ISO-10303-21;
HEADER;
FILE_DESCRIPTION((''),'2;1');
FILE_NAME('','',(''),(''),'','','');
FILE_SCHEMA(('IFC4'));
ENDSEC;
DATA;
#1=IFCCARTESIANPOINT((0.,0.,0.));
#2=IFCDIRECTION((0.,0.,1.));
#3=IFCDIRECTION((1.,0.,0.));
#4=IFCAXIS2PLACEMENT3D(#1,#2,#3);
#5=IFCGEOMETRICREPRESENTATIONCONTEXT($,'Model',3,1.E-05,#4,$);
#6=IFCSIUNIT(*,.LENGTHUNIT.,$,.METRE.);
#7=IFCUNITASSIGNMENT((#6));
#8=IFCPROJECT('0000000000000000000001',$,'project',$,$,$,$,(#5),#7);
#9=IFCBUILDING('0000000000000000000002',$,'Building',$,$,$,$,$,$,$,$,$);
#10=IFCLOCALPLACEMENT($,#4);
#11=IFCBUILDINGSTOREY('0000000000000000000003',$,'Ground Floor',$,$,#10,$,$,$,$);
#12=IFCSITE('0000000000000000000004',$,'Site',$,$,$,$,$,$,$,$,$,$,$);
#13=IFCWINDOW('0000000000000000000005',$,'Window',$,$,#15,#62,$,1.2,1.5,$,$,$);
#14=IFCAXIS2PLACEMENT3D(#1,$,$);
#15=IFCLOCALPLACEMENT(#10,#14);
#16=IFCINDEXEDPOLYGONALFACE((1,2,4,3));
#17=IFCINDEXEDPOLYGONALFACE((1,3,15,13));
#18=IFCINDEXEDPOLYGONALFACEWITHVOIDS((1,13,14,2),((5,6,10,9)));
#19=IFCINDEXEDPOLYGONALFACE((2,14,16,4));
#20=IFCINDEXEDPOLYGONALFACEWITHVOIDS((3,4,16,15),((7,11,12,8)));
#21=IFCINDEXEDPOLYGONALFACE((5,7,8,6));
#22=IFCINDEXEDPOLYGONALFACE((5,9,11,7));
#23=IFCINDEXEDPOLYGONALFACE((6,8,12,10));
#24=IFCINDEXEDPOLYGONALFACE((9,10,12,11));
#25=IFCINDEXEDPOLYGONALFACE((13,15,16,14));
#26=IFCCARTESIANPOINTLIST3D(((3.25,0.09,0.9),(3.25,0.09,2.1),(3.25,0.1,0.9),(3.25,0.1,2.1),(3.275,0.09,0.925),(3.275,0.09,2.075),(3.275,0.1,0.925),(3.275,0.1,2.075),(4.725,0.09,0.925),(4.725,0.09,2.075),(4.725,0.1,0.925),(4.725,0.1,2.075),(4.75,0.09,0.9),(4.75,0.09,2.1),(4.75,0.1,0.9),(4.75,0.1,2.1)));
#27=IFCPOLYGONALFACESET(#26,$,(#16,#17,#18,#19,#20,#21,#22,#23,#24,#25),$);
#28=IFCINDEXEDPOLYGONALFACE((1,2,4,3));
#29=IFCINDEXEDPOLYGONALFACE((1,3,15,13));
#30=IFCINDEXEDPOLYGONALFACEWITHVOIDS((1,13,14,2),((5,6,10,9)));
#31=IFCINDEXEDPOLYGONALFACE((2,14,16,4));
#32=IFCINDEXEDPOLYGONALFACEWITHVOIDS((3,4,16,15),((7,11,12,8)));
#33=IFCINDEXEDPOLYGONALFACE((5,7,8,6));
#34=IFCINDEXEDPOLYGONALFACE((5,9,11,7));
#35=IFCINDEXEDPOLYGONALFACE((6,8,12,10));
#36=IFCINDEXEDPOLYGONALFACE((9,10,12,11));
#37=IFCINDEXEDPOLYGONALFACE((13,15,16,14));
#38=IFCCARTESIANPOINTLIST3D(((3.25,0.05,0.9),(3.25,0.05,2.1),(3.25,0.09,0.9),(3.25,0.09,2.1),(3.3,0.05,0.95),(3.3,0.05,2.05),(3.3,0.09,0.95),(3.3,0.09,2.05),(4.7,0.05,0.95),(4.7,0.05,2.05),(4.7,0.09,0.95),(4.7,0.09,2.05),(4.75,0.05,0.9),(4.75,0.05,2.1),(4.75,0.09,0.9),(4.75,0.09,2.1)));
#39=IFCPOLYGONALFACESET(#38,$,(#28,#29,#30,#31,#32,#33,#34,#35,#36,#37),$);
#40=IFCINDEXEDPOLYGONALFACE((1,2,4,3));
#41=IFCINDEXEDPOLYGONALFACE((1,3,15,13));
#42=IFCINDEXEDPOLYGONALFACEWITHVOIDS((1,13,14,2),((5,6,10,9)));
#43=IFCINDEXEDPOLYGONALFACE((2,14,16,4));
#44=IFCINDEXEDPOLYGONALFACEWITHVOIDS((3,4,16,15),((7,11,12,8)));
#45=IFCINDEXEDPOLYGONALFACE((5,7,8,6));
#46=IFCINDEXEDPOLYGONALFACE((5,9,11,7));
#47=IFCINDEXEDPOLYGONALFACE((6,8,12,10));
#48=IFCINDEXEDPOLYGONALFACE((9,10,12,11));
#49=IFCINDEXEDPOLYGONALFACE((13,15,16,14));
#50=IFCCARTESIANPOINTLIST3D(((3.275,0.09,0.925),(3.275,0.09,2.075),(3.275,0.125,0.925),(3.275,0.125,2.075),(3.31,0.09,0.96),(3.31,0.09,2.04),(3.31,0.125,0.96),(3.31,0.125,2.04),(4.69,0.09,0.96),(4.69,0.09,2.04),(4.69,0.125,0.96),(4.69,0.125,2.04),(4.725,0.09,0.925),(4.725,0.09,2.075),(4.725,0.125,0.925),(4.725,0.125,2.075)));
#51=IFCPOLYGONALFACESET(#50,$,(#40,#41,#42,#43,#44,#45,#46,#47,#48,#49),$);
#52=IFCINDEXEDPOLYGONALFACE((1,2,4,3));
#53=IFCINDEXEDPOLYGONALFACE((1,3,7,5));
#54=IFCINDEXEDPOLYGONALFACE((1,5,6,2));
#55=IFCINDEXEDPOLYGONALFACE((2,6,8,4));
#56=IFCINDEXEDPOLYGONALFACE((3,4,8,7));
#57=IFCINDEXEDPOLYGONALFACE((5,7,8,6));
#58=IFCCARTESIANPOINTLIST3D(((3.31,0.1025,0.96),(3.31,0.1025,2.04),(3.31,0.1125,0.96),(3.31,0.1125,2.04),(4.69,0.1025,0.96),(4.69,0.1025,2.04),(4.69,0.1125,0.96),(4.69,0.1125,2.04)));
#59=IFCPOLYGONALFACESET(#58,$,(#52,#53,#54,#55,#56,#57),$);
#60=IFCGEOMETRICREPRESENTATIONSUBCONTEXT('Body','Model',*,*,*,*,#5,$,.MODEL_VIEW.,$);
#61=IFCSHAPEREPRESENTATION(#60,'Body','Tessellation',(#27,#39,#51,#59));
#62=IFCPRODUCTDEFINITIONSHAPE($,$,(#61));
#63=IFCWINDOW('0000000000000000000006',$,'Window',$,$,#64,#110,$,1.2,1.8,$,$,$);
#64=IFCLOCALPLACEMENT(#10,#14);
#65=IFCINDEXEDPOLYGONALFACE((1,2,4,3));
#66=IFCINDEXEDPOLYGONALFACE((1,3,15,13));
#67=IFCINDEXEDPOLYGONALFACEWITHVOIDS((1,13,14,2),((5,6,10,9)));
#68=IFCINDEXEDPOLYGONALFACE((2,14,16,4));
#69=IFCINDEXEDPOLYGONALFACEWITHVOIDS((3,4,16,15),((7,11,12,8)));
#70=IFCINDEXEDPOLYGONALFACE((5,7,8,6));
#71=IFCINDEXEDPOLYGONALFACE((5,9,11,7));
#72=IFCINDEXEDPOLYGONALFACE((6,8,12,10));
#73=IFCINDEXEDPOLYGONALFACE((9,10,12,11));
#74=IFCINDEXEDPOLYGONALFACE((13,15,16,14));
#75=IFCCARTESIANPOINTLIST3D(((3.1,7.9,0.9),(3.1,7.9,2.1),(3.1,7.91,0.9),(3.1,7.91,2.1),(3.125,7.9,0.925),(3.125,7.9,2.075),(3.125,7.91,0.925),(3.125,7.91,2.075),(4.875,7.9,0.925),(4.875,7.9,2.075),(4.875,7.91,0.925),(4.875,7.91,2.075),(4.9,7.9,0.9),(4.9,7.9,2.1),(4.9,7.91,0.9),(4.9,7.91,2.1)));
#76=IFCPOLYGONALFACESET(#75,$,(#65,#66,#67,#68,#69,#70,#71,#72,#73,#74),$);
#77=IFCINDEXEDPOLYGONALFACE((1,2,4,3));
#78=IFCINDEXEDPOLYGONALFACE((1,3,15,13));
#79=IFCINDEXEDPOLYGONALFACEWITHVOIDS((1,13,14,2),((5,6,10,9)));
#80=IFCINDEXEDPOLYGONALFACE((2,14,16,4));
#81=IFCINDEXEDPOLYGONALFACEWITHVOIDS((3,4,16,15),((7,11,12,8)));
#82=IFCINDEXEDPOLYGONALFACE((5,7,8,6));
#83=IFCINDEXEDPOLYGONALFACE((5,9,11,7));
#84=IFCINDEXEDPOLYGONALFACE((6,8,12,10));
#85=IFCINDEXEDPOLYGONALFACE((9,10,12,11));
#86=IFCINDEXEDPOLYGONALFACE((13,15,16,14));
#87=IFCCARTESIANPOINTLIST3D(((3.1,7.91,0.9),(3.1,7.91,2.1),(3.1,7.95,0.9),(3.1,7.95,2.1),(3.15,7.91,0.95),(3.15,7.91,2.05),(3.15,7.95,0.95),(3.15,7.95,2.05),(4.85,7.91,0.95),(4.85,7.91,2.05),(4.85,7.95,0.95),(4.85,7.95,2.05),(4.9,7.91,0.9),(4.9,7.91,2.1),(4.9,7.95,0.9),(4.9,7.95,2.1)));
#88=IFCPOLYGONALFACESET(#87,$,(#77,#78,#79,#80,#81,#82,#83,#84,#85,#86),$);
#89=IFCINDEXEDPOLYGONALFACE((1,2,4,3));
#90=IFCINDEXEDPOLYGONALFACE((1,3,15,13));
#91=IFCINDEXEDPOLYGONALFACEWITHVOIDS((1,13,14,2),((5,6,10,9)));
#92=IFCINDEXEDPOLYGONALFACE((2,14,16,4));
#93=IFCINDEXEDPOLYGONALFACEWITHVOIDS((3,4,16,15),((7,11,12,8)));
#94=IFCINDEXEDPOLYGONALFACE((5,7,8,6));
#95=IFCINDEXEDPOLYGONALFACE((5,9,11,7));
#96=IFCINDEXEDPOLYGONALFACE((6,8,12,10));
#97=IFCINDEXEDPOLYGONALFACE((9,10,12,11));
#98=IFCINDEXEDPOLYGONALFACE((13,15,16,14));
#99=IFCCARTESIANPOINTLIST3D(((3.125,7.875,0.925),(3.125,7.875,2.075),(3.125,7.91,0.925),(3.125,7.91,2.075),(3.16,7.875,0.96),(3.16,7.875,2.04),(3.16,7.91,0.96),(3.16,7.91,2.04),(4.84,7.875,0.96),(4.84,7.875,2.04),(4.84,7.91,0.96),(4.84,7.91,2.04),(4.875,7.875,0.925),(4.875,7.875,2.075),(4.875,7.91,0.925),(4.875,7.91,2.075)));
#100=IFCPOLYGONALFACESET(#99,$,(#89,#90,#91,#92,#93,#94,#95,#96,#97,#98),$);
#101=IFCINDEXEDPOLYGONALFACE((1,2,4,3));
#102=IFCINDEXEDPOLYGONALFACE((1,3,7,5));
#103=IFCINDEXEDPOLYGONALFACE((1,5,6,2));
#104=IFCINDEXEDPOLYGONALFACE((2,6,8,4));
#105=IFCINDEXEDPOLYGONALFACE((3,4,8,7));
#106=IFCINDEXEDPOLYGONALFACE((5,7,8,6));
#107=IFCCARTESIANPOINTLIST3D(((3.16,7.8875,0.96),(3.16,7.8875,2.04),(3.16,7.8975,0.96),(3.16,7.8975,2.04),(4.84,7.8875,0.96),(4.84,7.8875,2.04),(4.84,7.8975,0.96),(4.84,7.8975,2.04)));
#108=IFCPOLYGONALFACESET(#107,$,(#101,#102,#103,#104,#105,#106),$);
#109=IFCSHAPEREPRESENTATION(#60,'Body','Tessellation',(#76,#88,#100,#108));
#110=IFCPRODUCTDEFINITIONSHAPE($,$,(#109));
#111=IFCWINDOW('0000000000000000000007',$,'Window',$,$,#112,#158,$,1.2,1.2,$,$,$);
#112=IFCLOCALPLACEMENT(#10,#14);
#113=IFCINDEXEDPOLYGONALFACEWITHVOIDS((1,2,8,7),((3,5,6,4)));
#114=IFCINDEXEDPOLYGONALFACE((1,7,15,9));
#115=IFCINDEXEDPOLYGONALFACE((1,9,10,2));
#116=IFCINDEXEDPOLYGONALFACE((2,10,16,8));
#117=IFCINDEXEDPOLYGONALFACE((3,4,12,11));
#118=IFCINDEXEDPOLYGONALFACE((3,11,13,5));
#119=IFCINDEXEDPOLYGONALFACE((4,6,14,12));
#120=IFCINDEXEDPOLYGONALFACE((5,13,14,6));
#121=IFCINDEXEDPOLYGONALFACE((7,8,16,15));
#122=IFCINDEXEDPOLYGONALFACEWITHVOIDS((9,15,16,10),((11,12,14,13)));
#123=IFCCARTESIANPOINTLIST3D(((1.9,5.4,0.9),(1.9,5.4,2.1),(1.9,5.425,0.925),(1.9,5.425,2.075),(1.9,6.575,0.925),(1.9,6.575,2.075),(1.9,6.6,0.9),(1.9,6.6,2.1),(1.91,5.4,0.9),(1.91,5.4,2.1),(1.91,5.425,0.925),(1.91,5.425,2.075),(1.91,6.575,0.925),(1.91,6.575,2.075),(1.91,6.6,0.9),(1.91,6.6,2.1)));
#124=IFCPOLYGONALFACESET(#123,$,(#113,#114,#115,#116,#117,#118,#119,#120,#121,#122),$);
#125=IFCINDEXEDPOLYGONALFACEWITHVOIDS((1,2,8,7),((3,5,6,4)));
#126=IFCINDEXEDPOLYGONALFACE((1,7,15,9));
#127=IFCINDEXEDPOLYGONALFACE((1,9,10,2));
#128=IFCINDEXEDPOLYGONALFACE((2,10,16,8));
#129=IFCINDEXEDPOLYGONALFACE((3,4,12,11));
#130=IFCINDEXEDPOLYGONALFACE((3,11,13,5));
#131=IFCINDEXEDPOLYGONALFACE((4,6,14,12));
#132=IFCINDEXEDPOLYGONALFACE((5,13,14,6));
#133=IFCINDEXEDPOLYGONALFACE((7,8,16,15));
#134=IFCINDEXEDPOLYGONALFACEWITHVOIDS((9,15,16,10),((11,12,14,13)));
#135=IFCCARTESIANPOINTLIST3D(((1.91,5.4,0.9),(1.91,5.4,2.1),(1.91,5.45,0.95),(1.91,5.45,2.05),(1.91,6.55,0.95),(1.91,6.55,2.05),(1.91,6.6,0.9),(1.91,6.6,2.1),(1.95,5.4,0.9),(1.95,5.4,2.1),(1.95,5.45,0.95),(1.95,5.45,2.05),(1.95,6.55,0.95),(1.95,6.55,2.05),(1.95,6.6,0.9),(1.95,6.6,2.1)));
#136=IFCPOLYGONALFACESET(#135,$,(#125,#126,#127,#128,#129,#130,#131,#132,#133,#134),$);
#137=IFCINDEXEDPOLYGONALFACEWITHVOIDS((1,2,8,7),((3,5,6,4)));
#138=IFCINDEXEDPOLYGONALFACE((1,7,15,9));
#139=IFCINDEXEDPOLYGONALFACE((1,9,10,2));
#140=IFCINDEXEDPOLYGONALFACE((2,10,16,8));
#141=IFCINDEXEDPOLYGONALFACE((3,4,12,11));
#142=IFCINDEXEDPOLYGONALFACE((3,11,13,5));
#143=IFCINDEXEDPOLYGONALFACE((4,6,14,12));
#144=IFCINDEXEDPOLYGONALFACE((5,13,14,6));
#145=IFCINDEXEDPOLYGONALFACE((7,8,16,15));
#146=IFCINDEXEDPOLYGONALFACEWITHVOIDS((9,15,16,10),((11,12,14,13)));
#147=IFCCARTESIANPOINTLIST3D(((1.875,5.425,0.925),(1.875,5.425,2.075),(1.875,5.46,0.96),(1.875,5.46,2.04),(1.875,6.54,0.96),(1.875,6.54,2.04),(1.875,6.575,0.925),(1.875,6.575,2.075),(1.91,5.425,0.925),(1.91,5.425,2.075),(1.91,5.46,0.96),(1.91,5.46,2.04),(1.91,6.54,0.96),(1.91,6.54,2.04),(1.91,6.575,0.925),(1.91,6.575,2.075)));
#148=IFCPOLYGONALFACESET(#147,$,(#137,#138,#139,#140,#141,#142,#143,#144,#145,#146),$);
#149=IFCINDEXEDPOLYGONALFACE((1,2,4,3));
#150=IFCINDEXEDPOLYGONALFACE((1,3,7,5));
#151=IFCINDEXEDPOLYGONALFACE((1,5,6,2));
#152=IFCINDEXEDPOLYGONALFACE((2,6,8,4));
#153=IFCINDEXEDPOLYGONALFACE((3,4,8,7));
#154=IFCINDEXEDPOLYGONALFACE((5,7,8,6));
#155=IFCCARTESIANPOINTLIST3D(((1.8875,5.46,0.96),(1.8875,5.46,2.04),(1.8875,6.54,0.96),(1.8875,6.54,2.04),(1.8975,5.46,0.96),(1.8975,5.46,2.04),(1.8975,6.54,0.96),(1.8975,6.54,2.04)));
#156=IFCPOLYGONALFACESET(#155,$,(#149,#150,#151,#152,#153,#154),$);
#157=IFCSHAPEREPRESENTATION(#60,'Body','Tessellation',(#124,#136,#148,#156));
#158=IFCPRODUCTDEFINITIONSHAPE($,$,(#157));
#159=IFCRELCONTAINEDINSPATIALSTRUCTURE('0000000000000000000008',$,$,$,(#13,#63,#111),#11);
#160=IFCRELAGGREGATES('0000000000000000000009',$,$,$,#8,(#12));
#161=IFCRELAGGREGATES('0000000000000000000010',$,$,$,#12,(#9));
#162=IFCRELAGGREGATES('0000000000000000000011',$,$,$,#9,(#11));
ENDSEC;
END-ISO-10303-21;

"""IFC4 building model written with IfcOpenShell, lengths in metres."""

from ifc_helpers import new_model, si_unit, frame, origin_with_axes, place, context, subcontext, project, spatial, line, indexed_curve, outline, extrude, element, save


model = new_model("IFC4")

# Units and contexts
model_context = context("Model", 3, precision=1e-05, world=origin_with_axes())
body_context = subcontext(model_context, "Body", "Model", "MODEL_VIEW")
ifc_project = project(units=[si_unit("LENGTHUNIT", "METRE")], contexts=[model_context])

# Site, building, storey
site = spatial("IfcSite", under=ifc_project, Name="Site")
building = spatial("IfcBuilding", under=site, Name="Building")
storey_placement = place(None, origin_with_axes())
storey = spatial("IfcBuildingStorey", under=building, at=storey_placement, Name="Ground Floor")

# Windows
window_1_placement = place(storey_placement, frame((3.25, 0.0, 0.9), z_axis=(0.0, 0.0, 1.0), x_axis=(1.0, 0.0, 0.0)))
element("IfcWindow", 1, at=window_1_placement, inside=storey, Name="Window", OverallHeight=1.2, OverallWidth=1.5, context=body_context, shape_type="SweptSolid", body=[
    extrude(outline(indexed_curve([(0.0, 0.0), (1.5, 0.0), (1.5, 1.2), (0.0, 1.2)], segments=[line(1, 2, 3, 4, 1)]), holes=[indexed_curve([(0.025, 0.025), (1.475, 0.025), (1.475, 1.175), (0.025, 1.175)], segments=[line(1, 2, 3, 4, 1)])]), frame((0.0, 0.09, 0.0), z_axis=(0.0, -1.0, 0.0), x_axis=(1.0, 0.0, 0.0)), (0.0, 0.0, -1.0), 0.01),
    extrude(outline(indexed_curve([(0.0, 0.0), (1.5, 0.0), (1.5, 1.2), (0.0, 1.2)], segments=[line(1, 2, 3, 4, 1)]), holes=[indexed_curve([(0.05, 0.05), (1.45, 0.05), (1.45, 1.15), (0.05, 1.15)], segments=[line(1, 2, 3, 4, 1)])]), frame((0.0, 0.05, 0.0), z_axis=(0.0, -1.0, 0.0), x_axis=(1.0, 0.0, 0.0)), (0.0, 0.0, -1.0), 0.04),
    extrude(outline(indexed_curve([(0.0, 0.0), (1.45, 0.0), (1.45, 1.15), (0.0, 1.15)], segments=[line(1, 2, 3, 4, 1)]), holes=[indexed_curve([(0.035, 0.035), (1.415, 0.035), (1.415, 1.115), (0.035, 1.115)], segments=[line(1, 2, 3, 4, 1)])]), frame((0.025, 0.09, 0.025), z_axis=(0.0, -1.0, 0.0), x_axis=(1.0, 0.0, 0.0)), (0.0, 0.0, -1.0), 0.035),
    extrude(outline(indexed_curve([(0.035, 0.035), (1.415, 0.035), (1.415, 1.115), (0.035, 1.115)], segments=[line(1, 2, 3, 4, 1)])), frame((0.025, 0.1025, 0.025), z_axis=(0.0, -1.0, 0.0), x_axis=(1.0, 0.0, 0.0)), (0.0, 0.0, -1.0), 0.01),
])
window_2_placement = place(storey_placement, frame((4.9, 8.0, 0.9), z_axis=(0.0, 0.0, 1.0), x_axis=(-1.0, 0.0, 0.0)))
element("IfcWindow", 2, at=window_2_placement, inside=storey, Name="Window", OverallHeight=1.2, OverallWidth=1.8, context=body_context, shape_type="SweptSolid", body=[
    extrude(outline(indexed_curve([(0.0, 0.0), (1.8, 0.0), (1.8, 1.2), (0.0, 1.2)], segments=[line(1, 2, 3, 4, 1)]), holes=[indexed_curve([(0.025, 0.025), (1.775, 0.025), (1.775, 1.175), (0.025, 1.175)], segments=[line(1, 2, 3, 4, 1)])]), frame((0.0, 0.09, 0.0), z_axis=(0.0, -1.0, 0.0), x_axis=(1.0, 0.0, 0.0)), (0.0, 0.0, -1.0), 0.01),
    extrude(outline(indexed_curve([(0.0, 0.0), (1.8, 0.0), (1.8, 1.2), (0.0, 1.2)], segments=[line(1, 2, 3, 4, 1)]), holes=[indexed_curve([(0.05, 0.05), (1.75, 0.05), (1.75, 1.15), (0.05, 1.15)], segments=[line(1, 2, 3, 4, 1)])]), frame((0.0, 0.05, 0.0), z_axis=(0.0, -1.0, 0.0), x_axis=(1.0, 0.0, 0.0)), (0.0, 0.0, -1.0), 0.04),
    extrude(outline(indexed_curve([(0.0, 0.0), (1.75, 0.0), (1.75, 1.15), (0.0, 1.15)], segments=[line(1, 2, 3, 4, 1)]), holes=[indexed_curve([(0.035, 0.035), (1.715, 0.035), (1.715, 1.115), (0.035, 1.115)], segments=[line(1, 2, 3, 4, 1)])]), frame((0.025, 0.09, 0.025), z_axis=(0.0, -1.0, 0.0), x_axis=(1.0, 0.0, 0.0)), (0.0, 0.0, -1.0), 0.035),
    extrude(outline(indexed_curve([(0.035, 0.035), (1.715, 0.035), (1.715, 1.115), (0.035, 1.115)], segments=[line(1, 2, 3, 4, 1)])), frame((0.025, 0.1025, 0.025), z_axis=(0.0, -1.0, 0.0), x_axis=(1.0, 0.0, 0.0)), (0.0, 0.0, -1.0), 0.01),
])
window_3_placement = place(storey_placement, frame((2.0, 5.4, 0.9), z_axis=(0.0, 0.0, 1.0), x_axis=(0.0, 1.0, 0.0)))
element("IfcWindow", 3, at=window_3_placement, inside=storey, Name="Window", OverallHeight=1.2, OverallWidth=1.2, context=body_context, shape_type="SweptSolid", body=[
    extrude(outline(indexed_curve([(0.0, 0.0), (1.2, 0.0), (1.2, 1.2), (0.0, 1.2)], segments=[line(1, 2, 3, 4, 1)]), holes=[indexed_curve([(0.025, 0.025), (1.175, 0.025), (1.175, 1.175), (0.025, 1.175)], segments=[line(1, 2, 3, 4, 1)])]), frame((0.0, 0.09, 0.0), z_axis=(0.0, -1.0, 0.0), x_axis=(1.0, 0.0, 0.0)), (0.0, 0.0, -1.0), 0.01),
    extrude(outline(indexed_curve([(0.0, 0.0), (1.2, 0.0), (1.2, 1.2), (0.0, 1.2)], segments=[line(1, 2, 3, 4, 1)]), holes=[indexed_curve([(0.05, 0.05), (1.15, 0.05), (1.15, 1.15), (0.05, 1.15)], segments=[line(1, 2, 3, 4, 1)])]), frame((0.0, 0.05, 0.0), z_axis=(0.0, -1.0, 0.0), x_axis=(1.0, 0.0, 0.0)), (0.0, 0.0, -1.0), 0.04),
    extrude(outline(indexed_curve([(0.0, 0.0), (1.15, 0.0), (1.15, 1.15), (0.0, 1.15)], segments=[line(1, 2, 3, 4, 1)]), holes=[indexed_curve([(0.035, 0.035), (1.115, 0.035), (1.115, 1.115), (0.035, 1.115)], segments=[line(1, 2, 3, 4, 1)])]), frame((0.025, 0.09, 0.025), z_axis=(0.0, -1.0, 0.0), x_axis=(1.0, 0.0, 0.0)), (0.0, 0.0, -1.0), 0.035),
    extrude(outline(indexed_curve([(0.035, 0.035), (1.115, 0.035), (1.115, 1.115), (0.035, 1.115)], segments=[line(1, 2, 3, 4, 1)])), frame((0.025, 0.1025, 0.025), z_axis=(0.0, -1.0, 0.0), x_axis=(1.0, 0.0, 0.0)), (0.0, 0.0, -1.0), 0.01),
])

save(model, "model.ifc")
